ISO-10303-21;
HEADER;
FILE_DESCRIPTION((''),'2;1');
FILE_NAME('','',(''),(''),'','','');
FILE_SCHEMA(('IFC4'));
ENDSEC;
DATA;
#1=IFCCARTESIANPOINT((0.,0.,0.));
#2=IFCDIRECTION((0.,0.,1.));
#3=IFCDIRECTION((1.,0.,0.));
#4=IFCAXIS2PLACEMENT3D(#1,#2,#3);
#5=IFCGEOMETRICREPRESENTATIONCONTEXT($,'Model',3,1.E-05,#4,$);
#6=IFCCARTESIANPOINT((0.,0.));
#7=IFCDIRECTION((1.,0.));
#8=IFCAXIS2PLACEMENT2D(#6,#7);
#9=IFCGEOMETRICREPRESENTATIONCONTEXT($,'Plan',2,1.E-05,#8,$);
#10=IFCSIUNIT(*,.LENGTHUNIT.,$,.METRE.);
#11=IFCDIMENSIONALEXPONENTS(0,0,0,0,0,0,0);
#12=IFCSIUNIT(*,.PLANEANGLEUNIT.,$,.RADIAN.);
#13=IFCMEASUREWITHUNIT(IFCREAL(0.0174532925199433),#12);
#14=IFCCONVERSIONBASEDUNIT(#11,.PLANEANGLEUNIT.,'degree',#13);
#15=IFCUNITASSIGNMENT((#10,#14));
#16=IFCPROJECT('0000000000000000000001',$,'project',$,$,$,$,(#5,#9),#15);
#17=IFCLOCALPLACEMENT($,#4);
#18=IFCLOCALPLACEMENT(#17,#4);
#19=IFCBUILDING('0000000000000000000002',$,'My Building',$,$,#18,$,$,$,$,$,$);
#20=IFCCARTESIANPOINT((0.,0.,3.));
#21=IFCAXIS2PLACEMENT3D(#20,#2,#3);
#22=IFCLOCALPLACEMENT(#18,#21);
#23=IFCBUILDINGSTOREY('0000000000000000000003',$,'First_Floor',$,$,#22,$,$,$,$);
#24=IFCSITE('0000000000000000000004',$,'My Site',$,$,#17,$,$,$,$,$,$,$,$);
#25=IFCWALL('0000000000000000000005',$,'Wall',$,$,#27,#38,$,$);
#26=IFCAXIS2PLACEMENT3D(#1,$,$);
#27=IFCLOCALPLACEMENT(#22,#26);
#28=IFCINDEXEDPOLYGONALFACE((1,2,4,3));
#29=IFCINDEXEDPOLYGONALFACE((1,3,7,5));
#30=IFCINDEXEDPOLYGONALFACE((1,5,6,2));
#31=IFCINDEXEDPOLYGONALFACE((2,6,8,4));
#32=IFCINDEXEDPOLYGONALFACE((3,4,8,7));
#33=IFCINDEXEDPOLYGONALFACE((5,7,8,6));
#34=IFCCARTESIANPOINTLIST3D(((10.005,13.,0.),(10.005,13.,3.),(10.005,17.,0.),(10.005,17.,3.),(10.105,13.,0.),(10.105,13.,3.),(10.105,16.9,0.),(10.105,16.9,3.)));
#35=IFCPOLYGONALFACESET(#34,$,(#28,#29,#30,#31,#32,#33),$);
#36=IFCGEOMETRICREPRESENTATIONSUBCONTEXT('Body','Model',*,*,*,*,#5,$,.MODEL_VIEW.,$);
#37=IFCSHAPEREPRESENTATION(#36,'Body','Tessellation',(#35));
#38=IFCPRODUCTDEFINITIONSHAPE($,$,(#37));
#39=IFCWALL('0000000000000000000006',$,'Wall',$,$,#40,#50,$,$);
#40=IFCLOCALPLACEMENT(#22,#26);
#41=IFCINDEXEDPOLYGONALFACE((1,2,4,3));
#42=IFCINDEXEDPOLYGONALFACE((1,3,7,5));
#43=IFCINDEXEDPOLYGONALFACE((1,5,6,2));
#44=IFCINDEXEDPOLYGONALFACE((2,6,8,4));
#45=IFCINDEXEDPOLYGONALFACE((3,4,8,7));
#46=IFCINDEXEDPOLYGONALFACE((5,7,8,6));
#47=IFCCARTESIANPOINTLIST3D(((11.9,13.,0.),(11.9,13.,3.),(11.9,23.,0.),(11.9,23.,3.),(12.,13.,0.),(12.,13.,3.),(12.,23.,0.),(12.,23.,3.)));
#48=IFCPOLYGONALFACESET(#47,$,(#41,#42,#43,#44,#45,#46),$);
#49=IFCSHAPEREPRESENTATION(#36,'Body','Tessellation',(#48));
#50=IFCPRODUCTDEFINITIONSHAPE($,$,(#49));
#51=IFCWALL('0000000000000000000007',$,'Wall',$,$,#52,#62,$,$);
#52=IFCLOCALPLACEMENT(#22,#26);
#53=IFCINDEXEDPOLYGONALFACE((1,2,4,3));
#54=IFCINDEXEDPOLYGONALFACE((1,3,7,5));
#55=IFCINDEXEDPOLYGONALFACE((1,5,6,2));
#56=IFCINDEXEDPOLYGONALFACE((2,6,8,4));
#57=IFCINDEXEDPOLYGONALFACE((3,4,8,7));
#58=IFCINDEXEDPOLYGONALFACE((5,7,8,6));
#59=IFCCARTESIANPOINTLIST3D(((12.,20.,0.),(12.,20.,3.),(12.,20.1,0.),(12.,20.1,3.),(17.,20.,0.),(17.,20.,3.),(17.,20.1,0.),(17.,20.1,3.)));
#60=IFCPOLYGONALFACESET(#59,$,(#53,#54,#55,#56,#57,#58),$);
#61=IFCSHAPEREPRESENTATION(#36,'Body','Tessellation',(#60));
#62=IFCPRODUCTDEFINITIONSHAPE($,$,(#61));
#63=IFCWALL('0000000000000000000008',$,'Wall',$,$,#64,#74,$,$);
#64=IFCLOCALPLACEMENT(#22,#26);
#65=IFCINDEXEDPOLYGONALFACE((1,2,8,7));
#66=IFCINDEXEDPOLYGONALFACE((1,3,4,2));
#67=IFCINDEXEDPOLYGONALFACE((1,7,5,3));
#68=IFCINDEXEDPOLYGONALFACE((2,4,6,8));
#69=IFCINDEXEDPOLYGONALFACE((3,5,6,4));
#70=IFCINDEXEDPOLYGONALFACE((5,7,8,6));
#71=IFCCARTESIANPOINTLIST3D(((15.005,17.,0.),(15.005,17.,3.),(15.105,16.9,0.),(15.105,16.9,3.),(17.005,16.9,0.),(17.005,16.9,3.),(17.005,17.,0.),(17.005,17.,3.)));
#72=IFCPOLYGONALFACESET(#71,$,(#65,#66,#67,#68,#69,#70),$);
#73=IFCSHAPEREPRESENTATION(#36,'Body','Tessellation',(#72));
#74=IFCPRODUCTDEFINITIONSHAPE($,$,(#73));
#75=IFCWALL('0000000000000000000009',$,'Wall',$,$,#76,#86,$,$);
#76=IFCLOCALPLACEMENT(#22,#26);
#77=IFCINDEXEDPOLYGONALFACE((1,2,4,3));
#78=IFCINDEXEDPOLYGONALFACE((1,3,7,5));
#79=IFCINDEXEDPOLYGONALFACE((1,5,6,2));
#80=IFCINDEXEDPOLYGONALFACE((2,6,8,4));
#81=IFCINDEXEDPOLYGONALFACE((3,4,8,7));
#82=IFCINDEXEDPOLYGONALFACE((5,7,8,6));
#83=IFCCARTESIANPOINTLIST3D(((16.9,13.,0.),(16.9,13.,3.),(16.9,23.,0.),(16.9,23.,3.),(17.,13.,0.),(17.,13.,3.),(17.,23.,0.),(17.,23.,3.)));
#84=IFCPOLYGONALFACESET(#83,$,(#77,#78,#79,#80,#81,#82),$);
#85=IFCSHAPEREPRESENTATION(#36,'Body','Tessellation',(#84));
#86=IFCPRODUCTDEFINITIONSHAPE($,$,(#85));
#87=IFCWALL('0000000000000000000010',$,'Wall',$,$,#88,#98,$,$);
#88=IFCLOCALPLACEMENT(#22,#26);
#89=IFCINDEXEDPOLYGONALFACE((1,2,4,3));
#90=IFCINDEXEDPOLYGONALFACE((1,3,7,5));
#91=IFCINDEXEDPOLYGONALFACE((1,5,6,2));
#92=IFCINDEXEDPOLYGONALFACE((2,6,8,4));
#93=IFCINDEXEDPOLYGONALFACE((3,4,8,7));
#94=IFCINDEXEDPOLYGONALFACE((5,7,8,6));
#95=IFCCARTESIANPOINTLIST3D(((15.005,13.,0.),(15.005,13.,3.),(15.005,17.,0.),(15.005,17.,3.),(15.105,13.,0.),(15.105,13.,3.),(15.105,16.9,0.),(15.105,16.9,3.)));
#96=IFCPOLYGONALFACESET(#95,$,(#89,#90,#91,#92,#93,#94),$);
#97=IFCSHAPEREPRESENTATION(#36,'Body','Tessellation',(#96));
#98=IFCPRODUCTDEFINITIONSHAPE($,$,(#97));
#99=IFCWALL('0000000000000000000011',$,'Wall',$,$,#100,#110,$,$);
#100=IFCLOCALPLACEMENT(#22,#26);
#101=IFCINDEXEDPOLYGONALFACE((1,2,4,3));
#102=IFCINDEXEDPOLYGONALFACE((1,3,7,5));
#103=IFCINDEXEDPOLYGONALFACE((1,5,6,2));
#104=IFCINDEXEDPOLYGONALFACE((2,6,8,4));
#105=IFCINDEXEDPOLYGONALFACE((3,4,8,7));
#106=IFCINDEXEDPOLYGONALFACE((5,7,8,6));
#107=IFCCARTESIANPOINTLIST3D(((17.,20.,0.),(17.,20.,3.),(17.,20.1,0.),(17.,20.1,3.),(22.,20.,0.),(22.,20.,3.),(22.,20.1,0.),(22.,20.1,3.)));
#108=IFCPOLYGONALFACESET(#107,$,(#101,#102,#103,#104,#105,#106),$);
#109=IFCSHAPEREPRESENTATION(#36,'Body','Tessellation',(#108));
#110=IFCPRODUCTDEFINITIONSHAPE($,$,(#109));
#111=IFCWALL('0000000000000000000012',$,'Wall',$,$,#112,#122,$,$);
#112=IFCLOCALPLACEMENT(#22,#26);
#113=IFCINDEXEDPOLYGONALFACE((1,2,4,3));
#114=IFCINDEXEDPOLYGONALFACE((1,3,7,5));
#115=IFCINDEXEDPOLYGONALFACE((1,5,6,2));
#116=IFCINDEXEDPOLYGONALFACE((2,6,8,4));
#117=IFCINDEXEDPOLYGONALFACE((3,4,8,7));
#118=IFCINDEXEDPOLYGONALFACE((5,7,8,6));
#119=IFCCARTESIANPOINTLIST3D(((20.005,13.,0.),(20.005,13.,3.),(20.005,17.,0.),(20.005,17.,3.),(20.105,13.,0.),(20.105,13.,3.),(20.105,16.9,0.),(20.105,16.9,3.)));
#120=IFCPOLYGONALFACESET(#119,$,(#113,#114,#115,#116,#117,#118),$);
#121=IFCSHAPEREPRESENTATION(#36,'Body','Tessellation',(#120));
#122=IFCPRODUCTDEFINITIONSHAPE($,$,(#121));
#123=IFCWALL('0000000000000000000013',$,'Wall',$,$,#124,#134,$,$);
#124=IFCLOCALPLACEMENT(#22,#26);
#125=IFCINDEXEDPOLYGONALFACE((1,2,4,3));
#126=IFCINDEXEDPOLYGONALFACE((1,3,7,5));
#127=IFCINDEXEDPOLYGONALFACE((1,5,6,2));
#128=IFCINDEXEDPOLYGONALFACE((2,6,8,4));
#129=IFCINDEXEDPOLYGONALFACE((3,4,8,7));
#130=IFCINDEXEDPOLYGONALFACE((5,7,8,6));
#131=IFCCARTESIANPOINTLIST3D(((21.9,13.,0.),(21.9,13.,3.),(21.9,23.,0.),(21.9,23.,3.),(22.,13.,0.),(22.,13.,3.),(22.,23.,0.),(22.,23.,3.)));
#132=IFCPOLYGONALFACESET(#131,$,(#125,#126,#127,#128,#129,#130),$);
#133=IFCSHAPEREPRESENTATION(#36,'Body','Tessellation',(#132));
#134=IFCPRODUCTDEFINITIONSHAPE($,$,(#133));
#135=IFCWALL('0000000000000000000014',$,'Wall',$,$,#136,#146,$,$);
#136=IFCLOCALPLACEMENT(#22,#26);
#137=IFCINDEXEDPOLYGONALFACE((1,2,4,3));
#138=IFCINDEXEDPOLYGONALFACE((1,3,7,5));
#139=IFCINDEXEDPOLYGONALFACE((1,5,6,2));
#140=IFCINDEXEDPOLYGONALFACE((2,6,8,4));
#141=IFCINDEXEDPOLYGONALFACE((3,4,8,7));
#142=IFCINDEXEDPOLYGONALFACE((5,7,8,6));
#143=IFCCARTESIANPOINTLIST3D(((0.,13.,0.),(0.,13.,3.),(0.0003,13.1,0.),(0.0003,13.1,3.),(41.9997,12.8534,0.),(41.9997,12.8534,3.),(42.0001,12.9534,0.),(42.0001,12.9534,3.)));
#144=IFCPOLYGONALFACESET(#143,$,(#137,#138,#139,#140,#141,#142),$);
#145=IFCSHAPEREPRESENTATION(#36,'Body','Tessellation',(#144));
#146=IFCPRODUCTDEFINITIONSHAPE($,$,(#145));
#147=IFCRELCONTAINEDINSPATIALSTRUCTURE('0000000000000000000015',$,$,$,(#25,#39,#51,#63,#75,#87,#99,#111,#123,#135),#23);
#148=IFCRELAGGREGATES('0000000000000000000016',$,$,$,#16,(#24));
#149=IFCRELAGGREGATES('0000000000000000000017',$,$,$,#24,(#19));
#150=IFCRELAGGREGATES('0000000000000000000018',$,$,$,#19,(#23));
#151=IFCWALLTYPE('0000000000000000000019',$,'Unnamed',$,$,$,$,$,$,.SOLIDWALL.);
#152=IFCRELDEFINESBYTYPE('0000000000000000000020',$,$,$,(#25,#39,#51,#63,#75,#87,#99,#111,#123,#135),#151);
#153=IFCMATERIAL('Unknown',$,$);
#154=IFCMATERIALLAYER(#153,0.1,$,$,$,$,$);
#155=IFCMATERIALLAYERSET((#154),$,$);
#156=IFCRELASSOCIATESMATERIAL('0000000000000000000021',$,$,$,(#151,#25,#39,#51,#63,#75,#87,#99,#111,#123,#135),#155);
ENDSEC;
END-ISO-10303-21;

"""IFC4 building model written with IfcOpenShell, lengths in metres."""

from ifc_helpers import new_model, entity, si_unit, converted_unit, frame, origin_with_axes, origin_2d_with_axis, place, context, subcontext, project, spatial, line, indexed_curve, outline, extrude, material, layer, layer_set, layer_usage, type_object, element, save


model = new_model("IFC4")

# Units and contexts
model_context = context("Model", 3, precision=1e-05, world=origin_with_axes())
plan_context = context("Plan", 2, precision=1e-05, world=origin_2d_with_axis())
body_context = subcontext(model_context, "Body", "Model", "MODEL_VIEW")
ifc_project = project(units=[si_unit("LENGTHUNIT", "METRE"), converted_unit("PLANEANGLEUNIT", "degree", entity("IfcReal", 0.0174532925199433), si_unit("PLANEANGLEUNIT", "RADIAN"), dimensions=[0, 0, 0, 0, 0, 0, 0])], contexts=[model_context, plan_context])

# Site, building, storey
site_placement = place(None, origin_with_axes())
site = spatial("IfcSite", under=ifc_project, at=site_placement, Name="My Site")
building_placement = place(site_placement, origin_with_axes())
building = spatial("IfcBuilding", under=site, at=building_placement, Name="My Building")
storey_placement = place(building_placement, frame((0.0, 0.0, 3.0), z_axis=(0.0, 0.0, 1.0), x_axis=(1.0, 0.0, 0.0)))
storey = spatial("IfcBuildingStorey", under=building, at=storey_placement, Name="First_Floor")

# Shared definitions
ifc_material = material(Name="Unknown")

# Walls
ifc_layer_1 = layer(ifc_material, 0.1)
ifc_layer_set_1 = layer_set([ifc_layer_1])
wall_type = type_object("IfcWallType", Name="Unnamed", PredefinedType="SOLIDWALL", material=ifc_layer_set_1)
ifc_layer_usage_1 = layer_usage(ifc_layer_set_1, "AXIS2", "POSITIVE", 0.0)
wall_1_placement = place(storey_placement, frame((10.005, 17.0, 0.0), z_axis=(0.0, 0.0, 1.0), x_axis=(0.0, -1.0, 0.0)))
element("IfcWall", 1, at=wall_1_placement, inside=storey, type_object=wall_type, material=ifc_layer_usage_1, Name="Wall", context=body_context, shape_type="SweptSolid", body=[
    extrude(outline(indexed_curve([(0.0, 0.0), (0.1, 0.1), (4.0, 0.1), (4.0, 0.0)], segments=[line(1, 2, 3, 4, 1)])), origin_with_axes(), (0.0, 0.0, 1.0), 3.0),
])
ifc_layer_usage_2 = layer_usage(ifc_layer_set_1, "AXIS2", "POSITIVE", 0.0)
wall_2_placement = place(storey_placement, frame((11.9, 23.0, 0.0), z_axis=(0.0, 0.0, 1.0), x_axis=(0.0, -1.0, 0.0)))
element("IfcWall", 2, at=wall_2_placement, inside=storey, type_object=wall_type, material=ifc_layer_usage_2, Name="Wall", context=body_context, shape_type="SweptSolid", body=[
    extrude(outline(indexed_curve([(0.0, 0.0), (0.0, 0.1), (10.0, 0.1), (10.0, 0.0)], segments=[line(1, 2, 3, 4, 1)])), origin_with_axes(), (0.0, 0.0, 1.0), 3.0),
])
ifc_layer_usage_3 = layer_usage(ifc_layer_set_1, "AXIS2", "POSITIVE", 0.0)
wall_3_placement = place(storey_placement, frame((12.0, 20.0, 0.0), z_axis=(0.0, 0.0, 1.0), x_axis=(1.0, 0.0, 0.0)))
element("IfcWall", 3, at=wall_3_placement, inside=storey, type_object=wall_type, material=ifc_layer_usage_3, Name="Wall", context=body_context, shape_type="SweptSolid", body=[
    extrude(outline(indexed_curve([(0.0, 0.0), (0.0, 0.1), (5.0, 0.1), (5.0, 0.0)], segments=[line(1, 2, 3, 4, 1)])), origin_with_axes(), (0.0, 0.0, 1.0), 3.0),
])
ifc_layer_usage_4 = layer_usage(ifc_layer_set_1, "AXIS2", "POSITIVE", 0.0)
wall_4_placement = place(storey_placement, frame((17.005, 17.0, 0.0), z_axis=(0.0, 0.0, 1.0), x_axis=(-1.0, 0.0, 0.0)))
element("IfcWall", 4, at=wall_4_placement, inside=storey, type_object=wall_type, material=ifc_layer_usage_4, Name="Wall", context=body_context, shape_type="SweptSolid", body=[
    extrude(outline(indexed_curve([(0.0, 0.0), (0.0, 0.1), (1.9, 0.1), (2.0, 0.0)], segments=[line(1, 2, 3, 4, 1)])), origin_with_axes(), (0.0, 0.0, 1.0), 3.0),
])
ifc_layer_usage_5 = layer_usage(ifc_layer_set_1, "AXIS2", "POSITIVE", 0.0)
wall_5_placement = place(storey_placement, frame((16.9, 23.0, 0.0), z_axis=(0.0, 0.0, 1.0), x_axis=(0.0, -1.0, 0.0)))
element("IfcWall", 5, at=wall_5_placement, inside=storey, type_object=wall_type, material=ifc_layer_usage_5, Name="Wall", context=body_context, shape_type="SweptSolid", body=[
    extrude(outline(indexed_curve([(0.0, 0.0), (0.0, 0.1), (10.0, 0.1), (10.0, 0.0)], segments=[line(1, 2, 3, 4, 1)])), origin_with_axes(), (0.0, 0.0, 1.0), 3.0),
])
ifc_layer_usage_6 = layer_usage(ifc_layer_set_1, "AXIS2", "POSITIVE", 0.0)
wall_6_placement = place(storey_placement, frame((15.005, 17.0, 0.0), z_axis=(0.0, 0.0, 1.0), x_axis=(0.0, -1.0, 0.0)))
element("IfcWall", 6, at=wall_6_placement, inside=storey, type_object=wall_type, material=ifc_layer_usage_6, Name="Wall", context=body_context, shape_type="SweptSolid", body=[
    extrude(outline(indexed_curve([(0.0, 0.0), (0.1, 0.1), (4.0, 0.1), (4.0, 0.0)], segments=[line(1, 2, 3, 4, 1)])), origin_with_axes(), (0.0, 0.0, 1.0), 3.0),
])
ifc_layer_usage_7 = layer_usage(ifc_layer_set_1, "AXIS2", "POSITIVE", 0.0)
wall_7_placement = place(storey_placement, frame((17.0, 20.0, 0.0), z_axis=(0.0, 0.0, 1.0), x_axis=(1.0, 0.0, 0.0)))
element("IfcWall", 7, at=wall_7_placement, inside=storey, type_object=wall_type, material=ifc_layer_usage_7, Name="Wall", context=body_context, shape_type="SweptSolid", body=[
    extrude(outline(indexed_curve([(0.0, 0.0), (0.0, 0.1), (5.0, 0.1), (5.0, 0.0)], segments=[line(1, 2, 3, 4, 1)])), origin_with_axes(), (0.0, 0.0, 1.0), 3.0),
])
ifc_layer_usage_8 = layer_usage(ifc_layer_set_1, "AXIS2", "POSITIVE", 0.0)
wall_8_placement = place(storey_placement, frame((20.005, 17.0, 0.0), z_axis=(0.0, 0.0, 1.0), x_axis=(0.0, -1.0, 0.0)))
element("IfcWall", 8, at=wall_8_placement, inside=storey, type_object=wall_type, material=ifc_layer_usage_8, Name="Wall", context=body_context, shape_type="SweptSolid", body=[
    extrude(outline(indexed_curve([(0.0, 0.0), (0.1, 0.1), (4.0, 0.1), (4.0, 0.0)], segments=[line(1, 2, 3, 4, 1)])), origin_with_axes(), (0.0, 0.0, 1.0), 3.0),
])
ifc_layer_usage_9 = layer_usage(ifc_layer_set_1, "AXIS2", "POSITIVE", 0.0)
wall_9_placement = place(storey_placement, frame((21.9, 23.0, 0.0), z_axis=(0.0, 0.0, 1.0), x_axis=(0.0, -1.0, 0.0)))
element("IfcWall", 9, at=wall_9_placement, inside=storey, type_object=wall_type, material=ifc_layer_usage_9, Name="Wall", context=body_context, shape_type="SweptSolid", body=[
    extrude(outline(indexed_curve([(0.0, 0.0), (0.0, 0.1), (10.0, 0.1), (10.0, 0.0)], segments=[line(1, 2, 3, 4, 1)])), origin_with_axes(), (0.0, 0.0, 1.0), 3.0),
])
ifc_layer_usage_10 = layer_usage(ifc_layer_set_1, "AXIS2", "POSITIVE", 0.0)
wall_10_placement = place(storey_placement, frame((0.0, 13.0, 0.0), z_axis=(0.0, 0.0, 1.0), x_axis=(0.999994, -0.003491, 0.0)))
element("IfcWall", 10, at=wall_10_placement, inside=storey, type_object=wall_type, material=ifc_layer_usage_10, Name="Wall", context=body_context, shape_type="SweptSolid", body=[
    extrude(outline(indexed_curve([(0.0, 0.0), (0.0, 0.1), (42.0, 0.1), (42.0, 0.0)], segments=[line(1, 2, 3, 4, 1)])), origin_with_axes(), (0.0, 0.0, 1.0), 3.0),
])

save(model, "model.ifc")
